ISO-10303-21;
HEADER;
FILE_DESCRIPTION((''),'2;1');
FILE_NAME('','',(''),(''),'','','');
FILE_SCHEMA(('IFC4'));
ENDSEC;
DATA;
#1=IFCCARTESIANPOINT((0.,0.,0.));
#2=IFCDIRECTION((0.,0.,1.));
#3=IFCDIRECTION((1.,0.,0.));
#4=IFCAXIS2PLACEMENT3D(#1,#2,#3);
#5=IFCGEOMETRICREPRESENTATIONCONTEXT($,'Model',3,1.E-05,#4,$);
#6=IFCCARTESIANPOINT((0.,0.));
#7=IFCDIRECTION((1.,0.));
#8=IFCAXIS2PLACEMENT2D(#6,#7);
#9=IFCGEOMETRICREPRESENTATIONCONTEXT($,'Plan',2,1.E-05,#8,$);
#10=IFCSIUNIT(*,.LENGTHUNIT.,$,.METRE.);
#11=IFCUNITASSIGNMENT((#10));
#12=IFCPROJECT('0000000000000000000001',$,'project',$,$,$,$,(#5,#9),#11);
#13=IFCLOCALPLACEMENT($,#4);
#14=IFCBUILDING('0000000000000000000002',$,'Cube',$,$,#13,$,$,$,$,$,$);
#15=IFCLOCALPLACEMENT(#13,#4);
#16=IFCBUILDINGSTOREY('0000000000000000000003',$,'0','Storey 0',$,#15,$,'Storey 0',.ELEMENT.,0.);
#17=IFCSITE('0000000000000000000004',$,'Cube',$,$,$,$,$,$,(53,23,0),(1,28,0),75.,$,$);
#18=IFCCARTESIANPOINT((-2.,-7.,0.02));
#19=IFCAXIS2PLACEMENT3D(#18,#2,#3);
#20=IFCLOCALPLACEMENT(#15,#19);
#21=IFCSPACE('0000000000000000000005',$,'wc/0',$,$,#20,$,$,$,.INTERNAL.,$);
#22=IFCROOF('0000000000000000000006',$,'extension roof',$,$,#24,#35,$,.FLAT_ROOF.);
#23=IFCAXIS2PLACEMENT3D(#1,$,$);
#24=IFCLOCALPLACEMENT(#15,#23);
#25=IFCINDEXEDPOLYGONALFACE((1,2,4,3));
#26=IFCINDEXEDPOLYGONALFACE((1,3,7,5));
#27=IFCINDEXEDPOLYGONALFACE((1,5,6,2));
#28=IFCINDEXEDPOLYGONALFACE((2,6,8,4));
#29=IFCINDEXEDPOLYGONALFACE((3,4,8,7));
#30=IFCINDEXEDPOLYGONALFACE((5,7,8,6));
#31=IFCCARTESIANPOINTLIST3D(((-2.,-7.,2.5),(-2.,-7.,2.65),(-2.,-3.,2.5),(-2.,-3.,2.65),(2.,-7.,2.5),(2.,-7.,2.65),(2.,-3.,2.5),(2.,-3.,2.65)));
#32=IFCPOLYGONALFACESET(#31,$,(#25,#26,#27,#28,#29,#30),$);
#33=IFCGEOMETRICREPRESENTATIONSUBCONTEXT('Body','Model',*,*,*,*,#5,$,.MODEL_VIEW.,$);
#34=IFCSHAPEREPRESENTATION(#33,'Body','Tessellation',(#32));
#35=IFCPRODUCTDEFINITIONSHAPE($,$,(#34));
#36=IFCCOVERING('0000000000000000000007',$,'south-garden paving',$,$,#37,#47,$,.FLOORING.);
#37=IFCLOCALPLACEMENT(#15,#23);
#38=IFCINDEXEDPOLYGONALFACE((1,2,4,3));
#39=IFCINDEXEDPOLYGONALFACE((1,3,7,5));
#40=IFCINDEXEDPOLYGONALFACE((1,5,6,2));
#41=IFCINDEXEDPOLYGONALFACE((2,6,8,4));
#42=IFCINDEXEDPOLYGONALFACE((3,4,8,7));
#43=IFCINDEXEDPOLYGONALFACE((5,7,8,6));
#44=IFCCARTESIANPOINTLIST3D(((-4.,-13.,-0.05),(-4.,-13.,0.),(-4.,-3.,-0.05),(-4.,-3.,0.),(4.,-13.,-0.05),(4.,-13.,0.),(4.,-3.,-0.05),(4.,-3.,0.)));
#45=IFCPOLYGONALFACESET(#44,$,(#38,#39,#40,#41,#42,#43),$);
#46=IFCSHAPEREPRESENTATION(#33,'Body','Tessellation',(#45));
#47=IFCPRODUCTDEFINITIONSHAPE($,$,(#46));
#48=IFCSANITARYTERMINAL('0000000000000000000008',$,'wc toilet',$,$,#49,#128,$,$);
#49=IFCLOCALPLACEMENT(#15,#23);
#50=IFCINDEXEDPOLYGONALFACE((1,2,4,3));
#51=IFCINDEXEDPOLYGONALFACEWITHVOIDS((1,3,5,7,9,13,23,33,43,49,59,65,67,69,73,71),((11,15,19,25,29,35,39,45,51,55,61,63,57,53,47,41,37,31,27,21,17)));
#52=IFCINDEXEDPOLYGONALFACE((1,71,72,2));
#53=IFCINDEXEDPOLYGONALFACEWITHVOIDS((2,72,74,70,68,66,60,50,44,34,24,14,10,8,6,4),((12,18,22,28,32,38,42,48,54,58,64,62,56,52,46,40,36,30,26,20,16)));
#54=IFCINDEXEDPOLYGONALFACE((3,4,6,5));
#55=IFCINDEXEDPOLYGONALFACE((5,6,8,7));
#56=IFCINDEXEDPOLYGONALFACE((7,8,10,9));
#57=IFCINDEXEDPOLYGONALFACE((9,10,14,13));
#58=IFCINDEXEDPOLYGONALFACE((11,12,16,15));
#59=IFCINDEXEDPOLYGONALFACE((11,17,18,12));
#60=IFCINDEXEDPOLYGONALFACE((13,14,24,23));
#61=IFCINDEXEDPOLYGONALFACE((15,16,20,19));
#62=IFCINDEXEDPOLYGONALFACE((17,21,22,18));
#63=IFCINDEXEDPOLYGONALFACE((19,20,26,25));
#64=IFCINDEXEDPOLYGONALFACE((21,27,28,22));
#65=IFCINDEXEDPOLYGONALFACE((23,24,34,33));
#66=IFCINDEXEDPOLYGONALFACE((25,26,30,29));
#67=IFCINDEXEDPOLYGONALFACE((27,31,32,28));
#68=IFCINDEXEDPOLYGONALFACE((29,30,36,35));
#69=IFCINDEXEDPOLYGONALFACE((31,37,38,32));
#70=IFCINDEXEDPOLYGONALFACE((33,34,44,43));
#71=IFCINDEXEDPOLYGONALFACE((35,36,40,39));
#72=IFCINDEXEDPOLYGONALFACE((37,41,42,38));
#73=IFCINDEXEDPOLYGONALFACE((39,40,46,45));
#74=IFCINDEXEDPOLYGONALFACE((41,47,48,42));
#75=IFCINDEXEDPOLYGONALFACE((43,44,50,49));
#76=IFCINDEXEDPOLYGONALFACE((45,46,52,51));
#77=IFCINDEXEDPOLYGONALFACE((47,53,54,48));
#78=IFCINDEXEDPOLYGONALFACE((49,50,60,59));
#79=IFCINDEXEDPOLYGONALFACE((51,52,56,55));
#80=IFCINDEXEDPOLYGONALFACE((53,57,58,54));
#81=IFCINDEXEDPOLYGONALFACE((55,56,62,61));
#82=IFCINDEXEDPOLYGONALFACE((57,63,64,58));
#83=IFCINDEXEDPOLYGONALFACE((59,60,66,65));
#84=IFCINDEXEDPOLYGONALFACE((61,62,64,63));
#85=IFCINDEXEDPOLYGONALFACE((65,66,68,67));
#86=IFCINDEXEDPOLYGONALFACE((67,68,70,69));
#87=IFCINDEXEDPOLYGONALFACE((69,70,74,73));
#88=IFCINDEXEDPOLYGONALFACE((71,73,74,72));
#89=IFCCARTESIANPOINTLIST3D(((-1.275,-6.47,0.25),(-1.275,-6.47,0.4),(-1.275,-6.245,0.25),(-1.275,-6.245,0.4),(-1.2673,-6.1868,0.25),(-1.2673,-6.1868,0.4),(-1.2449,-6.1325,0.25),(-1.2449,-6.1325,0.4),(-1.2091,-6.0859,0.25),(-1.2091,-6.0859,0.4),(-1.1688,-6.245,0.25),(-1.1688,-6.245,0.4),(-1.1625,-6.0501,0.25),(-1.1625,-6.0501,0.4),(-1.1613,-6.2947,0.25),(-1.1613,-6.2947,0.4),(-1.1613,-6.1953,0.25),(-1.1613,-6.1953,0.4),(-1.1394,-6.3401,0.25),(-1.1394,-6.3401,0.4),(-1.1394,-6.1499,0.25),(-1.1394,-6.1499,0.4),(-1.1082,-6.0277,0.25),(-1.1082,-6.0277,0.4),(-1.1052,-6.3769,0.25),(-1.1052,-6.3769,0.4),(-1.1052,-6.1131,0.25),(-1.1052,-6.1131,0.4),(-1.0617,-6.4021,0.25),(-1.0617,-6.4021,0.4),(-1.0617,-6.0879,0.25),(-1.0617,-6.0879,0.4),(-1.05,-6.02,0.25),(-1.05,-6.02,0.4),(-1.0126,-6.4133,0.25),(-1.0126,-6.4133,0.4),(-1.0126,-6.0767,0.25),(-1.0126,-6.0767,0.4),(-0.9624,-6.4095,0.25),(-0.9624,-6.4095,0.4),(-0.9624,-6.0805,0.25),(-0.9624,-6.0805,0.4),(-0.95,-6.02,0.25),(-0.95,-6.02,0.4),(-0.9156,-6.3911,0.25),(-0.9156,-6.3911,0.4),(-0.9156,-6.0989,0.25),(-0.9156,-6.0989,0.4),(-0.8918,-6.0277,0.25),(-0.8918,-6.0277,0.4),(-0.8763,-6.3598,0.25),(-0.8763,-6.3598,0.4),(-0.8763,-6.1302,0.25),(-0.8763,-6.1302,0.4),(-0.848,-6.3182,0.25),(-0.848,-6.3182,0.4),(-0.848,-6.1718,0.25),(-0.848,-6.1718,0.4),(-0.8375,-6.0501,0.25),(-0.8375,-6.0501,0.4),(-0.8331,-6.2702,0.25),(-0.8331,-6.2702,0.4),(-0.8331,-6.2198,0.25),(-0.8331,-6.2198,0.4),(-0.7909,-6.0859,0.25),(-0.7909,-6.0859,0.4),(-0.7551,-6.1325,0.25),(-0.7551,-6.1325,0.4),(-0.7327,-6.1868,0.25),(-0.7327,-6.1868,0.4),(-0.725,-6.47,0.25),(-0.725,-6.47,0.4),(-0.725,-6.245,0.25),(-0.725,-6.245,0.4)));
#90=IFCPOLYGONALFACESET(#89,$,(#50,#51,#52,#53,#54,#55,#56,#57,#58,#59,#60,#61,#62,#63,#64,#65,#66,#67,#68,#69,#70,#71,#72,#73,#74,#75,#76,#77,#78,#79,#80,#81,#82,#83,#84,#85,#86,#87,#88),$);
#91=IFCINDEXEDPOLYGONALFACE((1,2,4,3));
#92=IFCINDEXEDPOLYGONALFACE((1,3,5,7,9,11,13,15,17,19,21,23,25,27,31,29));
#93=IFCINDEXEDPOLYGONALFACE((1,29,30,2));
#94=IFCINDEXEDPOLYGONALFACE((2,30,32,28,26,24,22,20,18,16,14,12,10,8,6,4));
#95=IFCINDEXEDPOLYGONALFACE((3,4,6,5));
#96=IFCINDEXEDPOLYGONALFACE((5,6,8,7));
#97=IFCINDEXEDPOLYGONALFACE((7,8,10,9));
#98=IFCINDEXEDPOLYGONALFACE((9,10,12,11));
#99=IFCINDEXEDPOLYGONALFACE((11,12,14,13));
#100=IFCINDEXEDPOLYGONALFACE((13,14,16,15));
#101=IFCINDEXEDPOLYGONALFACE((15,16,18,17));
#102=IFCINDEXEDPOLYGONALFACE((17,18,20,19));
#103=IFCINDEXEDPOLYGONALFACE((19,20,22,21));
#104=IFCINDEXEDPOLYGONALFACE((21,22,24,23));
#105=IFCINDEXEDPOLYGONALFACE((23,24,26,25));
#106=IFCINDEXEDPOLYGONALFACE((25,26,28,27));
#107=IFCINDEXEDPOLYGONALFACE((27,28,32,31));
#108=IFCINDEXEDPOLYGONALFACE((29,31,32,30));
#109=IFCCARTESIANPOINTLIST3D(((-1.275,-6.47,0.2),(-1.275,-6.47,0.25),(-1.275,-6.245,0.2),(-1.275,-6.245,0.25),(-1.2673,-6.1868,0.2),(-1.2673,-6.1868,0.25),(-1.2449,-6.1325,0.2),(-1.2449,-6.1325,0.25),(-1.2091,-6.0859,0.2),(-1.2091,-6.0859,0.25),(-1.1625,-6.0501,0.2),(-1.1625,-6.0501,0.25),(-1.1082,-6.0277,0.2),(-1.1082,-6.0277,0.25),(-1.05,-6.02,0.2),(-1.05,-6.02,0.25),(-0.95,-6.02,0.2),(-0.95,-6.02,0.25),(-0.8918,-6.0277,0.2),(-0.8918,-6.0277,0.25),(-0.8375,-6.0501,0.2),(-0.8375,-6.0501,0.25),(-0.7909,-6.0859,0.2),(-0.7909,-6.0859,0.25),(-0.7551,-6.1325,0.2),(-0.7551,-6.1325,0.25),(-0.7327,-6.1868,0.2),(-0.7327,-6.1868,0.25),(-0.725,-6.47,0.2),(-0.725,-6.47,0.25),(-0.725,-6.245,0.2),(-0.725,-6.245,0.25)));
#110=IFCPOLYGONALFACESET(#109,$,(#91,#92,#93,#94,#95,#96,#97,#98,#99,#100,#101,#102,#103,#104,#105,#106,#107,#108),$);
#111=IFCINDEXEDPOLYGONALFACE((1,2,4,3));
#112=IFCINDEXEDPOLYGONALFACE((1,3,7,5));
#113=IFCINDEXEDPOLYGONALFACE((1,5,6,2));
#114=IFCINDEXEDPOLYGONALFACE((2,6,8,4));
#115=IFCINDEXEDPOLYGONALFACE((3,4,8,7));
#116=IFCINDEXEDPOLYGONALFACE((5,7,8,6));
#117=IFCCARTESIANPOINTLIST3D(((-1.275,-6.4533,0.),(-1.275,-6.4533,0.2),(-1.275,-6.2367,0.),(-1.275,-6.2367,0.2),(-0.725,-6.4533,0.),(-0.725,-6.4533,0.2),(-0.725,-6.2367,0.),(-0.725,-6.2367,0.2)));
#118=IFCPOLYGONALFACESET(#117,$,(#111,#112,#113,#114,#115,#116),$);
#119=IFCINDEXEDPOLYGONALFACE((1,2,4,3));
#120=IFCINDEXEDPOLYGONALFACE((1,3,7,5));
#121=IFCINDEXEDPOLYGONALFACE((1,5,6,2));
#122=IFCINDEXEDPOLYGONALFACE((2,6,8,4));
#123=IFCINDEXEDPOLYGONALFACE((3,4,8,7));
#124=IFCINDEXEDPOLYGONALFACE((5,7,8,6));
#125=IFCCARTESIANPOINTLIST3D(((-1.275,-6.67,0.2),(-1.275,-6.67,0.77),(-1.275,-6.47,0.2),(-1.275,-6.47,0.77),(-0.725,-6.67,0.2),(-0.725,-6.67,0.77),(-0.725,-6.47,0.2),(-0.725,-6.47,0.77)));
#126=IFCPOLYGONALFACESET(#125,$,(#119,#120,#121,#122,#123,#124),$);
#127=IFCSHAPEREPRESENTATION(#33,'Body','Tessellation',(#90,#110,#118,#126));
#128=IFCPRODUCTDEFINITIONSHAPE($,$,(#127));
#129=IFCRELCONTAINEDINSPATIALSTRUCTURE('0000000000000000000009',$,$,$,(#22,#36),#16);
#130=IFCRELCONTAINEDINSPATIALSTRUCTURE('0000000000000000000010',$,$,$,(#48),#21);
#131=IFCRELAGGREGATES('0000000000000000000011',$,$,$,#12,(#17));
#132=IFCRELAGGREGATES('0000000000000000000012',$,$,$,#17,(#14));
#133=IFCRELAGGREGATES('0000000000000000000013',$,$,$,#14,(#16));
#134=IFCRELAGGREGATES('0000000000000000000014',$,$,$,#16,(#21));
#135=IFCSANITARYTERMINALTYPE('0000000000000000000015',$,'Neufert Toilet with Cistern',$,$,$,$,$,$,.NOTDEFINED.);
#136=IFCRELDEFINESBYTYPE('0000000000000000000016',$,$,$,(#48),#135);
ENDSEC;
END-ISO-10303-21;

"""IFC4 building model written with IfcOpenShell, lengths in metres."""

from ifc_helpers import new_model, entity, si_unit, frame, frame_2d, origin_with_axes, origin_2d_with_axis, place, context, subcontext, project, spatial, line, arc, indexed_curve, circle_curve, outline, extrude, shape, source, transform, mapped, type_object, type_shapes, element, save


model = new_model("IFC4")

# Units and contexts
model_context = context("Model", 3, precision=1e-05, world=origin_with_axes())
plan_context = context("Plan", 2, precision=1e-05, world=origin_2d_with_axis())
body_context_1 = subcontext(model_context, "Body", "Model", "MODEL_VIEW")
body_context_2 = subcontext(plan_context, "Body", "Plan", "PLAN_VIEW")
ifc_project = project(units=[si_unit("LENGTHUNIT", "METRE")], contexts=[model_context, plan_context])

# Site, building, storey
site = spatial("IfcSite", under=ifc_project, Name="Cube", RefLatitude=(53, 23, 0), RefLongitude=(1, 28, 0), RefElevation=75.0)
building_placement = place(None, origin_with_axes())
building = spatial("IfcBuilding", under=site, at=building_placement, Name="Cube")
storey_placement = place(building_placement, origin_with_axes())
storey = spatial("IfcBuildingStorey", under=building, at=storey_placement, Name="0", Description="Storey 0", LongName="Storey 0", CompositionType="ELEMENT", Elevation=0.0)

# Roof
roof_placement = place(storey_placement, frame((-2.0, -7.0, 2.5), z_axis=(0.0, 0.0, 1.0), x_axis=(1.0, 0.0, 0.0)))
element("IfcRoof", 1, at=roof_placement, inside=storey, Name="extension roof", PredefinedType="FLAT_ROOF", context=body_context_1, shape_type="SweptSolid", body=[
    extrude(outline(indexed_curve([(0.0, 0.0), (4.0, 0.0), (4.0, 4.0), (0.0, 4.0)])), None, (0.0, 0.0, 1.0), 0.15),
])

# Covering
covering_placement = place(storey_placement, frame((-4.0, -13.0, 0.0), z_axis=(0.0, 0.0, 1.0), x_axis=(1.0, 0.0, 0.0)))
element("IfcCovering", 2, at=covering_placement, inside=storey, Name="south-garden paving", PredefinedType="FLOORING", context=body_context_1, shape_type="SweptSolid", body=[
    extrude(outline(indexed_curve([(0.0, 0.0), (8.0, 0.0), (8.0, 10.0), (0.0, 10.0)])), None, (0.0, 0.0, -1.0), 0.05),
])

# Shared definitions
space_1_placement = place(storey_placement, frame((-2.0, -7.0, 0.02), z_axis=(0.0, 0.0, 1.0), x_axis=(1.0, 0.0, 0.0)))
space_1 = spatial("IfcSpace", under=storey, at=space_1_placement, Name="wc/0", PredefinedType="INTERNAL")

# Sanitary terminal
sanitary_terminal_type_1 = type_object("IfcSanitaryTerminalType", Name="Neufert Toilet with Cistern", PredefinedType="NOTDEFINED")
shared_shape_1 = source(origin_with_axes(), body_context_1, "Body", "SweptSolid", [
    extrude(outline(indexed_curve([(-0.275, -0.2), (0.275, -0.2), (0.275, -0.425), (0.2091, -0.5841), (0.05, -0.65), (-0.05, -0.65), (-0.2091, -0.5841), (-0.275, -0.425)], segments=[line(1, 2), line(2, 3), arc(3, 4, 5), line(5, 6), arc(6, 7, 8), line(8, 1)]), holes=[circle_curve(frame_2d((0.0, -0.425)), 0.1688)]), frame((0.0, 0.0, 0.25), z_axis=(0.0, 0.0, 1.0), x_axis=(1.0, 0.0, 0.0)), (0.0, 0.0, 1.0), 0.15),
    extrude(outline(indexed_curve([(-0.275, -0.2), (0.275, -0.2), (0.275, -0.425), (0.2091, -0.5841), (0.05, -0.65), (-0.05, -0.65), (-0.2091, -0.5841), (-0.275, -0.425)], segments=[line(1, 2), line(2, 3), arc(3, 4, 5), line(5, 6), arc(6, 7, 8), line(8, 1)])), frame((0.0, 0.0, 0.2), z_axis=(0.0, 0.0, 1.0), x_axis=(1.0, 0.0, 0.0)), (0.0, 0.0, 1.0), 0.05),
    extrude(outline(indexed_curve([(-0.275, -0.2167), (0.275, -0.2167), (0.275, -0.4333), (-0.275, -0.4333)], segments=[line(1, 2, 3, 4, 1)])), origin_with_axes(), (0.0, 0.0, 1.0), 0.2),
    extrude(outline(indexed_curve([(-0.275, 0.0), (0.275, 0.0), (0.275, -0.2), (-0.275, -0.2)], segments=[line(1, 2, 3, 4, 1)])), frame((0.0, 0.0, 0.2), z_axis=(0.0, 0.0, 1.0), x_axis=(1.0, 0.0, 0.0)), (0.0, 0.0, 1.0), 0.57),
])
shared_shape_2 = source(origin_with_axes(), body_context_2, "Body", "Curve2D", [
    entity("IfcIndexedPolyCurve", entity("IfcCartesianPointList2D", [[-0.275, 0.0], [0.275, 0.0], [0.275, -0.2], [-0.275, -0.2]]), [entity("IfcLineIndex", [1, 2, 3, 4, 1])]),
    entity("IfcIndexedPolyCurve", entity("IfcCartesianPointList2D", [[0.165, -0.2], [0.1925, -0.335]])),
    entity("IfcTrimmedCurve", entity("IfcEllipse", entity("IfcAxis2Placement2D", entity("IfcCartesianPoint", [0.0, -0.335]), entity("IfcDirection", [1.0, 0.0])), 0.1925, 0.315), [entity("IfcCartesianPoint", [-0.1925, -0.335])], [entity("IfcCartesianPoint", [0.1925, -0.335])], True, "CARTESIAN"),
    entity("IfcIndexedPolyCurve", entity("IfcCartesianPointList2D", [[-0.165, -0.2], [-0.1925, -0.335]])),
    entity("IfcEllipse", entity("IfcAxis2Placement2D", entity("IfcCartesianPoint", [0.0, -0.452]), entity("IfcDirection", [1.0, 0.0])), 0.1313, 0.1575),
    entity("IfcIndexedPolyCurve", entity("IfcCartesianPointList2D", [[-0.0344, -0.452], [-0.0344, -0.4295], [0.0344, -0.4295], [0.0344, -0.452]])),
    entity("IfcTrimmedCurve", entity("IfcEllipse", entity("IfcAxis2Placement2D", entity("IfcCartesianPoint", [0.0, -0.452]), entity("IfcDirection", [1.0, 0.0])), 0.0344, 0.0225), [entity("IfcCartesianPoint", [-0.0344, -0.452])], [entity("IfcCartesianPoint", [0.0344, -0.452])], True, "CARTESIAN"),
])
type_shapes(sanitary_terminal_type_1, [shared_shape_1, shared_shape_2])
sanitary_terminal_1_placement = place(space_1_placement, frame((1.0, 0.33, -0.02), z_axis=(0.0, 0.0, 1.0), x_axis=(-1.0, 0.0, 0.0)))
element("IfcSanitaryTerminal", 3, at=sanitary_terminal_1_placement, inside=space_1, type_object=sanitary_terminal_type_1, Name="wc toilet", shapes=[
    shape(body_context_1, "Body", "MappedRepresentation", [mapped(shared_shape_1, transform((0.0, 0.0, 0.0), x_axis=(1.0, 0.0, 0.0), y_axis=(0.0, 1.0, 0.0), z_axis=(0.0, 0.0, 1.0), scale=1.0))]),
    shape(body_context_2, "Body", "MappedRepresentation", [mapped(shared_shape_2, transform((0.0, 0.0, 0.0), x_axis=(1.0, 0.0, 0.0), y_axis=(0.0, 1.0, 0.0), z_axis=(0.0, 0.0, 1.0), scale=1.0))]),
])

save(model, "model.ifc")
